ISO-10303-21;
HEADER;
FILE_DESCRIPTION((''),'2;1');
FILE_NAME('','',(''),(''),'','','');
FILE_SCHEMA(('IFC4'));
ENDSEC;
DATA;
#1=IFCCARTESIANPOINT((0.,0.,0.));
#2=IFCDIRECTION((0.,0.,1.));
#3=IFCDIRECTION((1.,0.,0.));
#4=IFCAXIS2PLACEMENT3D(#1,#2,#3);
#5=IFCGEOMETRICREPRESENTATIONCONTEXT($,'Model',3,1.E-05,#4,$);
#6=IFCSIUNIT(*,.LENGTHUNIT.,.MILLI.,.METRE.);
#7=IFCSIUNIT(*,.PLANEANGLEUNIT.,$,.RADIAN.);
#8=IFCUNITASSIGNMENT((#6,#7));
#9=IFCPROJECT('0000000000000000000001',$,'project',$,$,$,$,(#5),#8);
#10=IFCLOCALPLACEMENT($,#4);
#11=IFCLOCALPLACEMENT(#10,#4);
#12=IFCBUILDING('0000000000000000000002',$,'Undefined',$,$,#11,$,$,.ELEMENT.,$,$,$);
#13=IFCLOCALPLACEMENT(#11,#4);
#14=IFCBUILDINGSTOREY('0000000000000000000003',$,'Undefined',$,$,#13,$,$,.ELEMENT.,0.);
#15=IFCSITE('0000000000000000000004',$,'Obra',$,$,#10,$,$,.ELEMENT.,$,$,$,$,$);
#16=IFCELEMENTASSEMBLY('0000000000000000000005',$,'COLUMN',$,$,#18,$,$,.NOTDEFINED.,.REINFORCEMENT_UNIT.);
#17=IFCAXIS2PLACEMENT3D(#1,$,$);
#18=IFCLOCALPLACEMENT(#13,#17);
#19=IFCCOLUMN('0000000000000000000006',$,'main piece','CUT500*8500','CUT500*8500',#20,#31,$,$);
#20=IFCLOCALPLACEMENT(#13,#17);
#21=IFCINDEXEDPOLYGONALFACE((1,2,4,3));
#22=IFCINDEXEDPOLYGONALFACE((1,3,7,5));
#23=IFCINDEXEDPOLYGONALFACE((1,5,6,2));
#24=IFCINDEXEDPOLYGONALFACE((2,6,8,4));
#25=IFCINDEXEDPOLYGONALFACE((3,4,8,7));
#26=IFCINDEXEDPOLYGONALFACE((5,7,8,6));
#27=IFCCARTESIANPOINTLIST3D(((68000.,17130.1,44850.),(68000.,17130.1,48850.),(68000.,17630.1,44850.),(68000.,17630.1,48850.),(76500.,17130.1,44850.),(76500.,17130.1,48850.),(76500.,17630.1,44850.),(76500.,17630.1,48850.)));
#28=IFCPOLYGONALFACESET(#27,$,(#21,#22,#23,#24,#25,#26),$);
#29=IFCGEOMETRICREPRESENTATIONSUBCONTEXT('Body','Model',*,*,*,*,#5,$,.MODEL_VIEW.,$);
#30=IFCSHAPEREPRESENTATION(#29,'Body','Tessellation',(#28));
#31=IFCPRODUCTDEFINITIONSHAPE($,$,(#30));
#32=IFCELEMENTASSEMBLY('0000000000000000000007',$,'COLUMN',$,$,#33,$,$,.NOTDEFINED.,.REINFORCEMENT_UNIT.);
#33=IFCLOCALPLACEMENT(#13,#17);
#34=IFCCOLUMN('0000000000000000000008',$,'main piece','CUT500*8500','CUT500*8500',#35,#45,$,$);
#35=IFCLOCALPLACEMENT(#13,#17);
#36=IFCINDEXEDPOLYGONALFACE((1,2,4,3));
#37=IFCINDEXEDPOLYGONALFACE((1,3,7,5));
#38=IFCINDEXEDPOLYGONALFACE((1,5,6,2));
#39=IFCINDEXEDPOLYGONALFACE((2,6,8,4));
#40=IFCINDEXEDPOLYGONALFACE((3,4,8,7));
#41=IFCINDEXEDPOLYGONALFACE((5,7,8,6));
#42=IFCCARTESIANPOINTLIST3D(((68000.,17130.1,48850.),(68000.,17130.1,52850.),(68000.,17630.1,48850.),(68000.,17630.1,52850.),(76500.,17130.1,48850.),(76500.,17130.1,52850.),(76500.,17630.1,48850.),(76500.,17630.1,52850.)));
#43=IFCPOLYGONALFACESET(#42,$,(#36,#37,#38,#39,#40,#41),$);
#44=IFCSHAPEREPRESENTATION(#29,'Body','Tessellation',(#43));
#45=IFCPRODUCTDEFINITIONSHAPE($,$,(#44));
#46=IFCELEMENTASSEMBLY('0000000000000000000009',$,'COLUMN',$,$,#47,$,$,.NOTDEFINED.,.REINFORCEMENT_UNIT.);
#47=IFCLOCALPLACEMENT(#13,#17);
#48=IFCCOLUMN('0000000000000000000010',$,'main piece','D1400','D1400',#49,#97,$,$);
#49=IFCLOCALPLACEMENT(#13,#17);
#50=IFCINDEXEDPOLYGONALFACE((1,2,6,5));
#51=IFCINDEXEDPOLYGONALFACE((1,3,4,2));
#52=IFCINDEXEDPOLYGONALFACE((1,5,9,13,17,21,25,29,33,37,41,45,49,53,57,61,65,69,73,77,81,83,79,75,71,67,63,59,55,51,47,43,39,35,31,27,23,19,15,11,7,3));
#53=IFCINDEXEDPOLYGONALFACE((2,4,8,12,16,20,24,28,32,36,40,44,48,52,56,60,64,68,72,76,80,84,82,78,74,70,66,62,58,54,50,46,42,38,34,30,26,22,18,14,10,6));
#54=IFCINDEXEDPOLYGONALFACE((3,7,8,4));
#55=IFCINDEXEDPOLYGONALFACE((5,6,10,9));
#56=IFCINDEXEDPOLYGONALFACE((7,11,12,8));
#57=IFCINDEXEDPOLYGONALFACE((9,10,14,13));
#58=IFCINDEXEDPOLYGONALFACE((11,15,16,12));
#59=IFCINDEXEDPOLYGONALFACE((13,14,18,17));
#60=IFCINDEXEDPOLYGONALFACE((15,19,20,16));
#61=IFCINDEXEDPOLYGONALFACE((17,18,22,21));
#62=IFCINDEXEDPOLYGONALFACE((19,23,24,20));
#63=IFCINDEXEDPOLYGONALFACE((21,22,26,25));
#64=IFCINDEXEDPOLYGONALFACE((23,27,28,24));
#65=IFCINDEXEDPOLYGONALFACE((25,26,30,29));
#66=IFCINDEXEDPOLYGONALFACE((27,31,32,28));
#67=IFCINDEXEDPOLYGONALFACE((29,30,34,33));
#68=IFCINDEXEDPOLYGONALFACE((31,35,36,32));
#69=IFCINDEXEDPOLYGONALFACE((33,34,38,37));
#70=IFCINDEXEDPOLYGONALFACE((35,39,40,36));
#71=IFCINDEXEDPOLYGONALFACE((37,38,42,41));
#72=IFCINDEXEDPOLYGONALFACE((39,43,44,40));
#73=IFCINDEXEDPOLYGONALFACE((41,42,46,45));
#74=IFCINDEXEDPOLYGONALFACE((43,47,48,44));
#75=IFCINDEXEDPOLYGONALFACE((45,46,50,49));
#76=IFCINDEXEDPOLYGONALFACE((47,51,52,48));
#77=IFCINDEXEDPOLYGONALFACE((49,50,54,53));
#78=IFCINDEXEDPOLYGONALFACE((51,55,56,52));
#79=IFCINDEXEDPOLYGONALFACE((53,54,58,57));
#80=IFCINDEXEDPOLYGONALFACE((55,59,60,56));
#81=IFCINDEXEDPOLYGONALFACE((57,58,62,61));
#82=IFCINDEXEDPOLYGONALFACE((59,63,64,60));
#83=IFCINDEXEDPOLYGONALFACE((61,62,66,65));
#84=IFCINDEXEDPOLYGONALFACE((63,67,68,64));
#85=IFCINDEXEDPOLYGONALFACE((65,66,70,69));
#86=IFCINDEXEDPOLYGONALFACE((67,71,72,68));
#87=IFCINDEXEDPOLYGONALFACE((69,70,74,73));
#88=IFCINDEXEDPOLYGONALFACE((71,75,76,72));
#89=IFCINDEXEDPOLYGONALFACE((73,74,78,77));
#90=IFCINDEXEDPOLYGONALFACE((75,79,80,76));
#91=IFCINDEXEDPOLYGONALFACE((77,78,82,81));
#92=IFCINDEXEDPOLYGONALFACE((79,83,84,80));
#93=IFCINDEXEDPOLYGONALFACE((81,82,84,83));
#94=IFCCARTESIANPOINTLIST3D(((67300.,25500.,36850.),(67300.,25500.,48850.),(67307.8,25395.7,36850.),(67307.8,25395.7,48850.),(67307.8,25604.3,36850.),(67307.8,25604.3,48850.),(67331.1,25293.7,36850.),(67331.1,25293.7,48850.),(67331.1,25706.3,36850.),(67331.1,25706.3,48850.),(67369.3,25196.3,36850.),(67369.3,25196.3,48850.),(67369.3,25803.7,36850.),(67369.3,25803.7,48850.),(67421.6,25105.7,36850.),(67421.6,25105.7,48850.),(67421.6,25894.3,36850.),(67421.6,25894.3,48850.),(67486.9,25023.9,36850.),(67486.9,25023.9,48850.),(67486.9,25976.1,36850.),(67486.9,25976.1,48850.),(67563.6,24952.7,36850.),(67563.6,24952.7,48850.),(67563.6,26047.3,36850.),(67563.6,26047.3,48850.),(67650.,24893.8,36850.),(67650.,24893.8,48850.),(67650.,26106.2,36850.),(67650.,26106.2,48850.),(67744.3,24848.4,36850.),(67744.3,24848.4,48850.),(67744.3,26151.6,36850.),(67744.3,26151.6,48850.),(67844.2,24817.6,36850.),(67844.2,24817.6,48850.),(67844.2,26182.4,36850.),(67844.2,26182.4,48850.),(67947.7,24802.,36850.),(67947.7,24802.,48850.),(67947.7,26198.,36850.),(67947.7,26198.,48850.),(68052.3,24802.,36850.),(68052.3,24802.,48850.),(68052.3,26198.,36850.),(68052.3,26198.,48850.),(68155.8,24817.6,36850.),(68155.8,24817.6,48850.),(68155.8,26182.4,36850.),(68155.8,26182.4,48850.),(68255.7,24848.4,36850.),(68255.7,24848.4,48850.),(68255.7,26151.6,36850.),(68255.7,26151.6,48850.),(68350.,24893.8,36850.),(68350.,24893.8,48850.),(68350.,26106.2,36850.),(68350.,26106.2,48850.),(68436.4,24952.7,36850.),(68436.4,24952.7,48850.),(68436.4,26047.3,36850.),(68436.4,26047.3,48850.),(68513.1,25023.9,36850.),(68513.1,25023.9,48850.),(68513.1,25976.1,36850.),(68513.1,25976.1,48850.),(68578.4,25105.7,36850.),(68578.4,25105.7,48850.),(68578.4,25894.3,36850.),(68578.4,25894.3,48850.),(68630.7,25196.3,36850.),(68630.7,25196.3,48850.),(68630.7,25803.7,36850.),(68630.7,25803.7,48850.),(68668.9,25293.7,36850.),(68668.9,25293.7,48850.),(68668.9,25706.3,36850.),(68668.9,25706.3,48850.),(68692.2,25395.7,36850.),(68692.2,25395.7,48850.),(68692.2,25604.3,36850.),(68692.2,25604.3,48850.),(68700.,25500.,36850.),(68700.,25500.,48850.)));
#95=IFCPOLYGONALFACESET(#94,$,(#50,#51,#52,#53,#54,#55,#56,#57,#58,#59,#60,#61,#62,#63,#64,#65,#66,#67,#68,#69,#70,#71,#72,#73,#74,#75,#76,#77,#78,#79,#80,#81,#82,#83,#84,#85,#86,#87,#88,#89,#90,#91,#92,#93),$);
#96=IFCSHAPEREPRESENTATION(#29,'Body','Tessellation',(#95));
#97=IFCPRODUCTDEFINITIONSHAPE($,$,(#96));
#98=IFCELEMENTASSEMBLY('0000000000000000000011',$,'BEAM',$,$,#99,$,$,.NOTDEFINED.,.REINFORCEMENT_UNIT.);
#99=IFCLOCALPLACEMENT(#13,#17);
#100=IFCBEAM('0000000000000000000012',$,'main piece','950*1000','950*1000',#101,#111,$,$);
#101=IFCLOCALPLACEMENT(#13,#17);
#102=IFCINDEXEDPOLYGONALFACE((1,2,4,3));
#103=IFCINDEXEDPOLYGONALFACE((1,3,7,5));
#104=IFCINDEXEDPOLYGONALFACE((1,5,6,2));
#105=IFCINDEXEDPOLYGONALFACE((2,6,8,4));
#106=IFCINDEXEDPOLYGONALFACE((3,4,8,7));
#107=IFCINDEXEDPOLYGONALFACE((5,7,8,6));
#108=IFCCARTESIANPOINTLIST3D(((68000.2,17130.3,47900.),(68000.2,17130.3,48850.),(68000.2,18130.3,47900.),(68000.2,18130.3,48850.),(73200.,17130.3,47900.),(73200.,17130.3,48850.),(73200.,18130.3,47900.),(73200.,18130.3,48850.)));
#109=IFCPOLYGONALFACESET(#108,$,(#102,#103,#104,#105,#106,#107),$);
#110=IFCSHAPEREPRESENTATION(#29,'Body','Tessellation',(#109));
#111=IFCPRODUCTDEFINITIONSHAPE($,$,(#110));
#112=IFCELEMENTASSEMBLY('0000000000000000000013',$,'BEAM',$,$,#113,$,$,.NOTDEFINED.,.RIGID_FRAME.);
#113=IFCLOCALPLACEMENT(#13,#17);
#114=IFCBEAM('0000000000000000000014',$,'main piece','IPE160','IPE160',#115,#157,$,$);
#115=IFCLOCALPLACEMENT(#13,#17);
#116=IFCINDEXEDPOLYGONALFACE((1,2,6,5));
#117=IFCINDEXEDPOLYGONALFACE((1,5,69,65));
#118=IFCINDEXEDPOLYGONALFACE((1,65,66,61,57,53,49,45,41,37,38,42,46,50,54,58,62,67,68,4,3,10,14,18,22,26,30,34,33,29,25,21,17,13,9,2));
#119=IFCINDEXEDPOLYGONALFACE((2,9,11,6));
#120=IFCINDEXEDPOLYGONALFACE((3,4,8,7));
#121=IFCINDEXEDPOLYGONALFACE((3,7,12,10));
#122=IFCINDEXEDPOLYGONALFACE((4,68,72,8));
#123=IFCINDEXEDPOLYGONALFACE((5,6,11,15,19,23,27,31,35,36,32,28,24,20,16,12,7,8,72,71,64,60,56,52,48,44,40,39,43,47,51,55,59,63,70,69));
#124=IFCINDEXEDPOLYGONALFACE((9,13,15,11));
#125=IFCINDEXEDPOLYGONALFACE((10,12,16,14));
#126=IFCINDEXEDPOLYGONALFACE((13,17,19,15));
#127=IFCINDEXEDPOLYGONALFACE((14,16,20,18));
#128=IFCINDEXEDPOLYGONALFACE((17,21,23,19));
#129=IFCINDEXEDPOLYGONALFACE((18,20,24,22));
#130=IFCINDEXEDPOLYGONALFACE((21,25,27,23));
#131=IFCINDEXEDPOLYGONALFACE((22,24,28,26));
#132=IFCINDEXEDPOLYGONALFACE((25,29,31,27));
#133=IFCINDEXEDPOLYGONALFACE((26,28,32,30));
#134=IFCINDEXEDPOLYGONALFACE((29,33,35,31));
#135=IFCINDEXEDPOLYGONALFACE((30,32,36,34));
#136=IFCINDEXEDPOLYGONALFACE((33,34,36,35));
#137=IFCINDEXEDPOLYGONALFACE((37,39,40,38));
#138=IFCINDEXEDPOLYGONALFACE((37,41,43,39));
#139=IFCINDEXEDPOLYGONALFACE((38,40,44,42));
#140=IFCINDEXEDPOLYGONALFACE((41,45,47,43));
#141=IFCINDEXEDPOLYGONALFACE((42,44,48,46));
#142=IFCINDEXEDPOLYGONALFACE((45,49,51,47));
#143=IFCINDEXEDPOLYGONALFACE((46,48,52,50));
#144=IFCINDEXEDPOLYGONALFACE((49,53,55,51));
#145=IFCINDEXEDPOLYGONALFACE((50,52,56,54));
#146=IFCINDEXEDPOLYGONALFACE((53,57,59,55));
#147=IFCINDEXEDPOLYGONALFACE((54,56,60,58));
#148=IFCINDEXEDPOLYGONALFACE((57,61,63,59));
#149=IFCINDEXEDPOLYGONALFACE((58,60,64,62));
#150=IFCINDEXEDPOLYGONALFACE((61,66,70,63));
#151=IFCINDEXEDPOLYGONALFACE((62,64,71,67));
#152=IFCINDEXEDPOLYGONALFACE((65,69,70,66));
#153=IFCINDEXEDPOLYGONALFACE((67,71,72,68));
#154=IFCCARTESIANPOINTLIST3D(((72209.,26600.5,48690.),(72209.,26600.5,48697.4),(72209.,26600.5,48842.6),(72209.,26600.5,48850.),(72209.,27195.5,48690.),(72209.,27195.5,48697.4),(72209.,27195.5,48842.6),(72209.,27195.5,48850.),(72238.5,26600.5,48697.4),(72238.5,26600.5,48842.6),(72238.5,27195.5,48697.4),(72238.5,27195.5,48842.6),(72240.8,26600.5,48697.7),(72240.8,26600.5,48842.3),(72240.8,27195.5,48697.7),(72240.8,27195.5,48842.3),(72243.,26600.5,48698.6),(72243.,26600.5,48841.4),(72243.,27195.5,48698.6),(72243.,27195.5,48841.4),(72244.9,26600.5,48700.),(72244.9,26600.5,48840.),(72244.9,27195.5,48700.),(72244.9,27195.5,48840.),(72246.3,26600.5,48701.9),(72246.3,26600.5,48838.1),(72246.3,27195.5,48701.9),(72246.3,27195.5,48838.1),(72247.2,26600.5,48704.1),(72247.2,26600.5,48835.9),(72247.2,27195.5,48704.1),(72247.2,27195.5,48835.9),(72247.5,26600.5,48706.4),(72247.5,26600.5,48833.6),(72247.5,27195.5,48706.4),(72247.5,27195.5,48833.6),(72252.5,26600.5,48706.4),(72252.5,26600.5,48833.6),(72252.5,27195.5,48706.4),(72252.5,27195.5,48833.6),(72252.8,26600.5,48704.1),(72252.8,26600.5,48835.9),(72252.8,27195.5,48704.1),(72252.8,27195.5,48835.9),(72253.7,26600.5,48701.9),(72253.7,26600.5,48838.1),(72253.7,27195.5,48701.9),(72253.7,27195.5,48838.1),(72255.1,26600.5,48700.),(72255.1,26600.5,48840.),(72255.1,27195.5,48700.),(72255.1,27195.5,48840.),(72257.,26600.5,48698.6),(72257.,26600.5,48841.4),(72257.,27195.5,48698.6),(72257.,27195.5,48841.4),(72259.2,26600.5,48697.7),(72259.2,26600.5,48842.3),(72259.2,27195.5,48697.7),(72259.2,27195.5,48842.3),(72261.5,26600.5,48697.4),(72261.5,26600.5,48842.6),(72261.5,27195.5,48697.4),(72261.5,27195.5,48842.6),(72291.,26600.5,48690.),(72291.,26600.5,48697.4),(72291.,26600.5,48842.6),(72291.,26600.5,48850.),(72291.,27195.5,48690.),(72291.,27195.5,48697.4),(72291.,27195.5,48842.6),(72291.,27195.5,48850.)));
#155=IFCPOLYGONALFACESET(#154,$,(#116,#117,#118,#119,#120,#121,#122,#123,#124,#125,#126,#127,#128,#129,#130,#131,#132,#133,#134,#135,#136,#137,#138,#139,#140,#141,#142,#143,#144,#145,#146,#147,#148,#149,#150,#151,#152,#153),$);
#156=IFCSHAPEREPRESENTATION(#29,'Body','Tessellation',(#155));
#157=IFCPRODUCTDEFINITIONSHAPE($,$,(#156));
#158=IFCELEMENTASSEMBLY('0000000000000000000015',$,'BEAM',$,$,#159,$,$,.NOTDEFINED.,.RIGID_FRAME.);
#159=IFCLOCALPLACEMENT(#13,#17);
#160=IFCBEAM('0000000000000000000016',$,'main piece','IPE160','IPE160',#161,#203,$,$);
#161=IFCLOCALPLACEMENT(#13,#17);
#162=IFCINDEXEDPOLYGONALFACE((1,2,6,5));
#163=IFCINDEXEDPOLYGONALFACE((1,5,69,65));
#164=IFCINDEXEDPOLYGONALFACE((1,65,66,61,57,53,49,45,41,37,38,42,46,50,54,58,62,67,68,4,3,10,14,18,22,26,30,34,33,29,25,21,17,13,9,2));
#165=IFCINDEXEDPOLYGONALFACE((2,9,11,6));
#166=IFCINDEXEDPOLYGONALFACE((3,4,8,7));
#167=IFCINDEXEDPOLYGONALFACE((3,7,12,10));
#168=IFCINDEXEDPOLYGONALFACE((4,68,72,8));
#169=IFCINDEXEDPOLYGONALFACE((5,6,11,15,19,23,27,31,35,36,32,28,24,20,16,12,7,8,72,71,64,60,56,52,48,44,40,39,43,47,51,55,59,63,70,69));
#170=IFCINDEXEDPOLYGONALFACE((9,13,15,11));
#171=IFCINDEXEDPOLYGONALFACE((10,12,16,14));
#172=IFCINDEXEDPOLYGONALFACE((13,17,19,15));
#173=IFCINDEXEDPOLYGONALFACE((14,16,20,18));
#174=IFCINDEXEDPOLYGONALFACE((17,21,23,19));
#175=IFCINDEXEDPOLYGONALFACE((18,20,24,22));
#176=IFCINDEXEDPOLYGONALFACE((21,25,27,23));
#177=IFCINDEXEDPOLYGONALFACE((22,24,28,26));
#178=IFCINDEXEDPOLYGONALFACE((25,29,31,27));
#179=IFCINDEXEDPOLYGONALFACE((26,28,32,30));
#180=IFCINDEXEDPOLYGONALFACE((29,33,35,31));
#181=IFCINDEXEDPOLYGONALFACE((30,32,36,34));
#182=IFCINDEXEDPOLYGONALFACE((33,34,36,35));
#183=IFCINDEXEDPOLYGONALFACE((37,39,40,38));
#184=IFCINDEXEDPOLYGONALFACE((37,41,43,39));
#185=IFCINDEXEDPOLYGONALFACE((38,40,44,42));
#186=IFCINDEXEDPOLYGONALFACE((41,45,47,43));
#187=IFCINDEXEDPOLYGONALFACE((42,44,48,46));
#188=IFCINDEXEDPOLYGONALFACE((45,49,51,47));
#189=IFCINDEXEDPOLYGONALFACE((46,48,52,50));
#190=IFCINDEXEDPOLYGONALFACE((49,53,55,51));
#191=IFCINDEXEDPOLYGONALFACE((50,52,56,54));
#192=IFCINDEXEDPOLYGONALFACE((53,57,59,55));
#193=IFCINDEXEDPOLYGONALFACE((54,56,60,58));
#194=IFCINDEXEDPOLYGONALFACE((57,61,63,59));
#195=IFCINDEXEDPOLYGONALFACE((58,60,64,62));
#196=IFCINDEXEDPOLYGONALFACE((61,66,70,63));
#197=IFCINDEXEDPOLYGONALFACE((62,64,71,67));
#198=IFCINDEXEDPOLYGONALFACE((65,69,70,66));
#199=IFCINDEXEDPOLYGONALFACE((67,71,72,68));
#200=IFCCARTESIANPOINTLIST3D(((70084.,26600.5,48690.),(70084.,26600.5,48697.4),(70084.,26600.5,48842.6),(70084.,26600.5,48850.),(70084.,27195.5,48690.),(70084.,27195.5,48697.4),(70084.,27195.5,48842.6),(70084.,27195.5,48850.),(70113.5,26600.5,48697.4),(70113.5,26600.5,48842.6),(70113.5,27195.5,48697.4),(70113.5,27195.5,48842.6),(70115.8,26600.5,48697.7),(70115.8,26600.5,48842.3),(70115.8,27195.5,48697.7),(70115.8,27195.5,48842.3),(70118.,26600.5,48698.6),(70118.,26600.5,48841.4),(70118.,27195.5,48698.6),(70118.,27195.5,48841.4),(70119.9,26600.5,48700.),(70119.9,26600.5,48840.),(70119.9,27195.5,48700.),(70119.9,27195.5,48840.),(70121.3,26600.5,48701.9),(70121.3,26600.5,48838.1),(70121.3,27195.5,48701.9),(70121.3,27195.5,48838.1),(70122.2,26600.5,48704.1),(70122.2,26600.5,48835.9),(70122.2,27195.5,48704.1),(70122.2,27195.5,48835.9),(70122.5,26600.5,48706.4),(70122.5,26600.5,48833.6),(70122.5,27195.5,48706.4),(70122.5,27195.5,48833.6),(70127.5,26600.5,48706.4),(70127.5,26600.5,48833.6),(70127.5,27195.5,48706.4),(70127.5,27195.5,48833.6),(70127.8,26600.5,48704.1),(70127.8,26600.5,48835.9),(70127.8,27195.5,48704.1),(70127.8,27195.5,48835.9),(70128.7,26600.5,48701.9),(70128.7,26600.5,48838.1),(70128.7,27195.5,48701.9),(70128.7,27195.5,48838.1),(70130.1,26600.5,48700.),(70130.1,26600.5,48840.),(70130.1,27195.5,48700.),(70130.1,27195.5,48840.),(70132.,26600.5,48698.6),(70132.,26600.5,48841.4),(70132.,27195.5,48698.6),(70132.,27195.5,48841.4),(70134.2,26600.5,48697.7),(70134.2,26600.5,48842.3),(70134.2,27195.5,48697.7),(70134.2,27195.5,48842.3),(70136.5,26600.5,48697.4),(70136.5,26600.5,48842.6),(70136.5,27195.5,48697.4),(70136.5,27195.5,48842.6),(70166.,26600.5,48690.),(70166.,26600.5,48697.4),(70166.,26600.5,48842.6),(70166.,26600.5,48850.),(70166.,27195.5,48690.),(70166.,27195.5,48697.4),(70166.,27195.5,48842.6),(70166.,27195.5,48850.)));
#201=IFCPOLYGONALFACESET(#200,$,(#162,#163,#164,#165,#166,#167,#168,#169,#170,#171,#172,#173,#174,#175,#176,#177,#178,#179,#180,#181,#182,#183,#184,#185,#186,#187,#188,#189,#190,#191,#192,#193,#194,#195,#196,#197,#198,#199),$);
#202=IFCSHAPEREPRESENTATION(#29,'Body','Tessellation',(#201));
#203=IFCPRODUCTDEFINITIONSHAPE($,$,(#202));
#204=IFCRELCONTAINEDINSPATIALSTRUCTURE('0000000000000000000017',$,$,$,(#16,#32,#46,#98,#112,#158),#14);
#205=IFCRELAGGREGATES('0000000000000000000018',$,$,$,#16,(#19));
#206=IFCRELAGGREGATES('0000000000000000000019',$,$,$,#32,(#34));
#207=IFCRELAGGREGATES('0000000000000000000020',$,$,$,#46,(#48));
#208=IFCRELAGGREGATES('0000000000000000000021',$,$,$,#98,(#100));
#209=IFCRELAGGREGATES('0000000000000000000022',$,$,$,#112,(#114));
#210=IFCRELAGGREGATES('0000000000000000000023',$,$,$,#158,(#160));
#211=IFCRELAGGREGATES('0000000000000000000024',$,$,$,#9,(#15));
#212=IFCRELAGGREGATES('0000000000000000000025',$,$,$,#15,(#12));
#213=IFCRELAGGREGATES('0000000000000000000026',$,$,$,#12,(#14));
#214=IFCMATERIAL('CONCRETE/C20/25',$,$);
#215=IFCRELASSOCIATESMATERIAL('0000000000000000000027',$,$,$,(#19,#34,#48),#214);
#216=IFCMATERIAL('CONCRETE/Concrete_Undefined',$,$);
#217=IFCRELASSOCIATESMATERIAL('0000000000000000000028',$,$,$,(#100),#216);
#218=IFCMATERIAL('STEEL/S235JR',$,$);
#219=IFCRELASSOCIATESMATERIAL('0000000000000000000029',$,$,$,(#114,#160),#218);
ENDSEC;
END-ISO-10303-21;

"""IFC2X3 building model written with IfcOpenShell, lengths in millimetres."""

from ifc_helpers import new_model, si_unit, frame, origin_with_axes, origin_2d_with_axis, place, context, subcontext, project, spatial, rectangle, circle, i_section, extrude, material, element, aggregate, save


model = new_model("IFC2X3")

# Units and contexts
model_context = context("Model", 3, precision=1e-05, world=origin_with_axes())
body_context = subcontext(model_context, "Body", "Model", "MODEL_VIEW")
ifc_project = project(units=[si_unit("LENGTHUNIT", "METRE", prefix="MILLI"), si_unit("PLANEANGLEUNIT", "RADIAN")], contexts=[model_context])

# Site, building, storey
site_placement = place(None, origin_with_axes())
site = spatial("IfcSite", under=ifc_project, at=site_placement, Name="Obra", CompositionType="ELEMENT")
building_placement = place(site_placement, origin_with_axes())
building = spatial("IfcBuilding", under=site, at=building_placement, Name="Undefined", CompositionType="ELEMENT")
storey_placement = place(building_placement, origin_with_axes())
storey = spatial("IfcBuildingStorey", under=building, at=storey_placement, Name="Undefined", CompositionType="ELEMENT", Elevation=0.0)

# Element assemblies, columns
ifc_material_1 = material(Name="STEEL/S235JR")
ifc_material_2 = material(Name="CONCRETE/C20/25")
assembly_1_placement = place(storey_placement, origin_with_axes())
assembly_1 = element("IfcElementAssembly", 1, at=assembly_1_placement, inside=storey, Name="COLUMN", AssemblyPlace="NOTDEFINED", PredefinedType="REINFORCEMENT_UNIT")
column_1_placement = place(assembly_1_placement, frame((72250.0, 17380.1, 44850.0), z_axis=(0.0, 0.0, 1.0), x_axis=(-1.0, 0.0, 0.0)))
column_1 = element("IfcColumn", 2, at=column_1_placement, material=ifc_material_2, Name="main piece", Description="CUT500*8500", ObjectType="CUT500*8500", context=body_context, shape_type="SweptSolid", body=[
    extrude(rectangle(XDim=500.0, YDim=8500.0, at=origin_2d_with_axis()), frame((0.0, 0.0, 4000.0), z_axis=(0.0, 0.0, -1.0), x_axis=(0.0, 1.0, 0.0)), (0.0, 0.0, 1.0), 4000.0),
])
aggregate(assembly_1, [column_1])
assembly_2_placement = place(storey_placement, origin_with_axes())
assembly_2 = element("IfcElementAssembly", 3, at=assembly_2_placement, inside=storey, Name="COLUMN", AssemblyPlace="NOTDEFINED", PredefinedType="REINFORCEMENT_UNIT")
column_2_placement = place(assembly_2_placement, frame((72250.0, 17380.1, 48850.0), z_axis=(0.0, 0.0, 1.0), x_axis=(-1.0, 0.0, 0.0)))
column_2 = element("IfcColumn", 4, at=column_2_placement, material=ifc_material_2, Name="main piece", Description="CUT500*8500", ObjectType="CUT500*8500", context=body_context, shape_type="SweptSolid", body=[
    extrude(rectangle(XDim=500.0, YDim=8500.0, at=origin_2d_with_axis()), frame((0.0, 0.0, 4000.0), z_axis=(0.0, 0.0, -1.0), x_axis=(0.0, 1.0, 0.0)), (0.0, 0.0, 1.0), 4000.0),
])
aggregate(assembly_2, [column_2])
assembly_3_placement = place(storey_placement, origin_with_axes())
assembly_3 = element("IfcElementAssembly", 5, at=assembly_3_placement, inside=storey, Name="COLUMN", AssemblyPlace="NOTDEFINED", PredefinedType="REINFORCEMENT_UNIT")
column_3_placement = place(assembly_3_placement, frame((68000.0, 25500.0, 36850.0), z_axis=(0.0, 0.0, 1.0), x_axis=(0.0, 1.0, 0.0)))
column_3 = element("IfcColumn", 6, at=column_3_placement, material=ifc_material_2, Name="main piece", Description="D1400", ObjectType="D1400", context=body_context, shape_type="SweptSolid", body=[
    extrude(circle(Radius=700.0, at=origin_2d_with_axis()), frame((0.0, 0.0, 12000.0), z_axis=(0.0, 0.0, -1.0), x_axis=(0.0, 1.0, 0.0)), (0.0, 0.0, 1.0), 12000.0),
])
aggregate(assembly_3, [column_3])

# Element assemblies, beams
assembly_4_placement = place(storey_placement, origin_with_axes())
assembly_4 = element("IfcElementAssembly", 7, at=assembly_4_placement, inside=storey, Name="BEAM", AssemblyPlace="NOTDEFINED", PredefinedType="REINFORCEMENT_UNIT")
ifc_material_3 = material(Name="CONCRETE/Concrete_Undefined")
beam_1_placement = place(assembly_4_placement, frame((68000.2, 17630.3, 48375.0), z_axis=(0.0, 0.0, 1.0), x_axis=(1.0, 0.0, 0.0)))
beam_1 = element("IfcBeam", 8, at=beam_1_placement, material=ifc_material_3, Name="main piece", Description="950*1000", ObjectType="950*1000", context=body_context, shape_type="SweptSolid", body=[
    extrude(rectangle(XDim=1000.0, YDim=950.0, at=origin_2d_with_axis()), frame((5199.8, 0.0, 0.0), z_axis=(-1.0, 0.0, 0.0), x_axis=(0.0, -1.0, 0.0)), (0.0, 0.0, 1.0), 5199.8),
])
aggregate(assembly_4, [beam_1])
assembly_5_placement = place(storey_placement, origin_with_axes())
assembly_5 = element("IfcElementAssembly", 9, at=assembly_5_placement, inside=storey, Name="BEAM", AssemblyPlace="NOTDEFINED", PredefinedType="RIGID_FRAME")
beam_2_placement = place(assembly_5_placement, frame((72250.0, 26600.5, 48770.0), z_axis=(0.0, 0.0, 1.0), x_axis=(0.0, 1.0, 0.0)))
beam_2 = element("IfcBeam", 10, at=beam_2_placement, material=ifc_material_1, Name="main piece", Description="IPE160", ObjectType="IPE160", context=body_context, shape_type="SweptSolid", body=[
    extrude(i_section(OverallWidth=82.0, OverallDepth=160.0, WebThickness=5.0, FlangeThickness=7.4, FilletRadius=9.0, at=origin_2d_with_axis()), frame((595.1, 0.0, 0.0), z_axis=(-1.0, 0.0, 0.0), x_axis=(0.0, -1.0, 0.0)), (0.0, 0.0, 1.0), 595.0),
])
aggregate(assembly_5, [beam_2])
assembly_6_placement = place(storey_placement, origin_with_axes())
assembly_6 = element("IfcElementAssembly", 11, at=assembly_6_placement, inside=storey, Name="BEAM", AssemblyPlace="NOTDEFINED", PredefinedType="RIGID_FRAME")
beam_3_placement = place(assembly_6_placement, frame((70125.0, 26600.5, 48770.0), z_axis=(0.0, 0.0, 1.0), x_axis=(0.0, 1.0, 0.0)))
beam_3 = element("IfcBeam", 12, at=beam_3_placement, material=ifc_material_1, Name="main piece", Description="IPE160", ObjectType="IPE160", context=body_context, shape_type="SweptSolid", body=[
    extrude(i_section(OverallWidth=82.0, OverallDepth=160.0, WebThickness=5.0, FlangeThickness=7.4, FilletRadius=9.0, at=origin_2d_with_axis()), frame((595.1, 0.0, 0.0), z_axis=(-1.0, 0.0, 0.0), x_axis=(0.0, -1.0, 0.0)), (0.0, 0.0, 1.0), 595.0),
])
aggregate(assembly_6, [beam_3])

save(model, "model.ifc")
